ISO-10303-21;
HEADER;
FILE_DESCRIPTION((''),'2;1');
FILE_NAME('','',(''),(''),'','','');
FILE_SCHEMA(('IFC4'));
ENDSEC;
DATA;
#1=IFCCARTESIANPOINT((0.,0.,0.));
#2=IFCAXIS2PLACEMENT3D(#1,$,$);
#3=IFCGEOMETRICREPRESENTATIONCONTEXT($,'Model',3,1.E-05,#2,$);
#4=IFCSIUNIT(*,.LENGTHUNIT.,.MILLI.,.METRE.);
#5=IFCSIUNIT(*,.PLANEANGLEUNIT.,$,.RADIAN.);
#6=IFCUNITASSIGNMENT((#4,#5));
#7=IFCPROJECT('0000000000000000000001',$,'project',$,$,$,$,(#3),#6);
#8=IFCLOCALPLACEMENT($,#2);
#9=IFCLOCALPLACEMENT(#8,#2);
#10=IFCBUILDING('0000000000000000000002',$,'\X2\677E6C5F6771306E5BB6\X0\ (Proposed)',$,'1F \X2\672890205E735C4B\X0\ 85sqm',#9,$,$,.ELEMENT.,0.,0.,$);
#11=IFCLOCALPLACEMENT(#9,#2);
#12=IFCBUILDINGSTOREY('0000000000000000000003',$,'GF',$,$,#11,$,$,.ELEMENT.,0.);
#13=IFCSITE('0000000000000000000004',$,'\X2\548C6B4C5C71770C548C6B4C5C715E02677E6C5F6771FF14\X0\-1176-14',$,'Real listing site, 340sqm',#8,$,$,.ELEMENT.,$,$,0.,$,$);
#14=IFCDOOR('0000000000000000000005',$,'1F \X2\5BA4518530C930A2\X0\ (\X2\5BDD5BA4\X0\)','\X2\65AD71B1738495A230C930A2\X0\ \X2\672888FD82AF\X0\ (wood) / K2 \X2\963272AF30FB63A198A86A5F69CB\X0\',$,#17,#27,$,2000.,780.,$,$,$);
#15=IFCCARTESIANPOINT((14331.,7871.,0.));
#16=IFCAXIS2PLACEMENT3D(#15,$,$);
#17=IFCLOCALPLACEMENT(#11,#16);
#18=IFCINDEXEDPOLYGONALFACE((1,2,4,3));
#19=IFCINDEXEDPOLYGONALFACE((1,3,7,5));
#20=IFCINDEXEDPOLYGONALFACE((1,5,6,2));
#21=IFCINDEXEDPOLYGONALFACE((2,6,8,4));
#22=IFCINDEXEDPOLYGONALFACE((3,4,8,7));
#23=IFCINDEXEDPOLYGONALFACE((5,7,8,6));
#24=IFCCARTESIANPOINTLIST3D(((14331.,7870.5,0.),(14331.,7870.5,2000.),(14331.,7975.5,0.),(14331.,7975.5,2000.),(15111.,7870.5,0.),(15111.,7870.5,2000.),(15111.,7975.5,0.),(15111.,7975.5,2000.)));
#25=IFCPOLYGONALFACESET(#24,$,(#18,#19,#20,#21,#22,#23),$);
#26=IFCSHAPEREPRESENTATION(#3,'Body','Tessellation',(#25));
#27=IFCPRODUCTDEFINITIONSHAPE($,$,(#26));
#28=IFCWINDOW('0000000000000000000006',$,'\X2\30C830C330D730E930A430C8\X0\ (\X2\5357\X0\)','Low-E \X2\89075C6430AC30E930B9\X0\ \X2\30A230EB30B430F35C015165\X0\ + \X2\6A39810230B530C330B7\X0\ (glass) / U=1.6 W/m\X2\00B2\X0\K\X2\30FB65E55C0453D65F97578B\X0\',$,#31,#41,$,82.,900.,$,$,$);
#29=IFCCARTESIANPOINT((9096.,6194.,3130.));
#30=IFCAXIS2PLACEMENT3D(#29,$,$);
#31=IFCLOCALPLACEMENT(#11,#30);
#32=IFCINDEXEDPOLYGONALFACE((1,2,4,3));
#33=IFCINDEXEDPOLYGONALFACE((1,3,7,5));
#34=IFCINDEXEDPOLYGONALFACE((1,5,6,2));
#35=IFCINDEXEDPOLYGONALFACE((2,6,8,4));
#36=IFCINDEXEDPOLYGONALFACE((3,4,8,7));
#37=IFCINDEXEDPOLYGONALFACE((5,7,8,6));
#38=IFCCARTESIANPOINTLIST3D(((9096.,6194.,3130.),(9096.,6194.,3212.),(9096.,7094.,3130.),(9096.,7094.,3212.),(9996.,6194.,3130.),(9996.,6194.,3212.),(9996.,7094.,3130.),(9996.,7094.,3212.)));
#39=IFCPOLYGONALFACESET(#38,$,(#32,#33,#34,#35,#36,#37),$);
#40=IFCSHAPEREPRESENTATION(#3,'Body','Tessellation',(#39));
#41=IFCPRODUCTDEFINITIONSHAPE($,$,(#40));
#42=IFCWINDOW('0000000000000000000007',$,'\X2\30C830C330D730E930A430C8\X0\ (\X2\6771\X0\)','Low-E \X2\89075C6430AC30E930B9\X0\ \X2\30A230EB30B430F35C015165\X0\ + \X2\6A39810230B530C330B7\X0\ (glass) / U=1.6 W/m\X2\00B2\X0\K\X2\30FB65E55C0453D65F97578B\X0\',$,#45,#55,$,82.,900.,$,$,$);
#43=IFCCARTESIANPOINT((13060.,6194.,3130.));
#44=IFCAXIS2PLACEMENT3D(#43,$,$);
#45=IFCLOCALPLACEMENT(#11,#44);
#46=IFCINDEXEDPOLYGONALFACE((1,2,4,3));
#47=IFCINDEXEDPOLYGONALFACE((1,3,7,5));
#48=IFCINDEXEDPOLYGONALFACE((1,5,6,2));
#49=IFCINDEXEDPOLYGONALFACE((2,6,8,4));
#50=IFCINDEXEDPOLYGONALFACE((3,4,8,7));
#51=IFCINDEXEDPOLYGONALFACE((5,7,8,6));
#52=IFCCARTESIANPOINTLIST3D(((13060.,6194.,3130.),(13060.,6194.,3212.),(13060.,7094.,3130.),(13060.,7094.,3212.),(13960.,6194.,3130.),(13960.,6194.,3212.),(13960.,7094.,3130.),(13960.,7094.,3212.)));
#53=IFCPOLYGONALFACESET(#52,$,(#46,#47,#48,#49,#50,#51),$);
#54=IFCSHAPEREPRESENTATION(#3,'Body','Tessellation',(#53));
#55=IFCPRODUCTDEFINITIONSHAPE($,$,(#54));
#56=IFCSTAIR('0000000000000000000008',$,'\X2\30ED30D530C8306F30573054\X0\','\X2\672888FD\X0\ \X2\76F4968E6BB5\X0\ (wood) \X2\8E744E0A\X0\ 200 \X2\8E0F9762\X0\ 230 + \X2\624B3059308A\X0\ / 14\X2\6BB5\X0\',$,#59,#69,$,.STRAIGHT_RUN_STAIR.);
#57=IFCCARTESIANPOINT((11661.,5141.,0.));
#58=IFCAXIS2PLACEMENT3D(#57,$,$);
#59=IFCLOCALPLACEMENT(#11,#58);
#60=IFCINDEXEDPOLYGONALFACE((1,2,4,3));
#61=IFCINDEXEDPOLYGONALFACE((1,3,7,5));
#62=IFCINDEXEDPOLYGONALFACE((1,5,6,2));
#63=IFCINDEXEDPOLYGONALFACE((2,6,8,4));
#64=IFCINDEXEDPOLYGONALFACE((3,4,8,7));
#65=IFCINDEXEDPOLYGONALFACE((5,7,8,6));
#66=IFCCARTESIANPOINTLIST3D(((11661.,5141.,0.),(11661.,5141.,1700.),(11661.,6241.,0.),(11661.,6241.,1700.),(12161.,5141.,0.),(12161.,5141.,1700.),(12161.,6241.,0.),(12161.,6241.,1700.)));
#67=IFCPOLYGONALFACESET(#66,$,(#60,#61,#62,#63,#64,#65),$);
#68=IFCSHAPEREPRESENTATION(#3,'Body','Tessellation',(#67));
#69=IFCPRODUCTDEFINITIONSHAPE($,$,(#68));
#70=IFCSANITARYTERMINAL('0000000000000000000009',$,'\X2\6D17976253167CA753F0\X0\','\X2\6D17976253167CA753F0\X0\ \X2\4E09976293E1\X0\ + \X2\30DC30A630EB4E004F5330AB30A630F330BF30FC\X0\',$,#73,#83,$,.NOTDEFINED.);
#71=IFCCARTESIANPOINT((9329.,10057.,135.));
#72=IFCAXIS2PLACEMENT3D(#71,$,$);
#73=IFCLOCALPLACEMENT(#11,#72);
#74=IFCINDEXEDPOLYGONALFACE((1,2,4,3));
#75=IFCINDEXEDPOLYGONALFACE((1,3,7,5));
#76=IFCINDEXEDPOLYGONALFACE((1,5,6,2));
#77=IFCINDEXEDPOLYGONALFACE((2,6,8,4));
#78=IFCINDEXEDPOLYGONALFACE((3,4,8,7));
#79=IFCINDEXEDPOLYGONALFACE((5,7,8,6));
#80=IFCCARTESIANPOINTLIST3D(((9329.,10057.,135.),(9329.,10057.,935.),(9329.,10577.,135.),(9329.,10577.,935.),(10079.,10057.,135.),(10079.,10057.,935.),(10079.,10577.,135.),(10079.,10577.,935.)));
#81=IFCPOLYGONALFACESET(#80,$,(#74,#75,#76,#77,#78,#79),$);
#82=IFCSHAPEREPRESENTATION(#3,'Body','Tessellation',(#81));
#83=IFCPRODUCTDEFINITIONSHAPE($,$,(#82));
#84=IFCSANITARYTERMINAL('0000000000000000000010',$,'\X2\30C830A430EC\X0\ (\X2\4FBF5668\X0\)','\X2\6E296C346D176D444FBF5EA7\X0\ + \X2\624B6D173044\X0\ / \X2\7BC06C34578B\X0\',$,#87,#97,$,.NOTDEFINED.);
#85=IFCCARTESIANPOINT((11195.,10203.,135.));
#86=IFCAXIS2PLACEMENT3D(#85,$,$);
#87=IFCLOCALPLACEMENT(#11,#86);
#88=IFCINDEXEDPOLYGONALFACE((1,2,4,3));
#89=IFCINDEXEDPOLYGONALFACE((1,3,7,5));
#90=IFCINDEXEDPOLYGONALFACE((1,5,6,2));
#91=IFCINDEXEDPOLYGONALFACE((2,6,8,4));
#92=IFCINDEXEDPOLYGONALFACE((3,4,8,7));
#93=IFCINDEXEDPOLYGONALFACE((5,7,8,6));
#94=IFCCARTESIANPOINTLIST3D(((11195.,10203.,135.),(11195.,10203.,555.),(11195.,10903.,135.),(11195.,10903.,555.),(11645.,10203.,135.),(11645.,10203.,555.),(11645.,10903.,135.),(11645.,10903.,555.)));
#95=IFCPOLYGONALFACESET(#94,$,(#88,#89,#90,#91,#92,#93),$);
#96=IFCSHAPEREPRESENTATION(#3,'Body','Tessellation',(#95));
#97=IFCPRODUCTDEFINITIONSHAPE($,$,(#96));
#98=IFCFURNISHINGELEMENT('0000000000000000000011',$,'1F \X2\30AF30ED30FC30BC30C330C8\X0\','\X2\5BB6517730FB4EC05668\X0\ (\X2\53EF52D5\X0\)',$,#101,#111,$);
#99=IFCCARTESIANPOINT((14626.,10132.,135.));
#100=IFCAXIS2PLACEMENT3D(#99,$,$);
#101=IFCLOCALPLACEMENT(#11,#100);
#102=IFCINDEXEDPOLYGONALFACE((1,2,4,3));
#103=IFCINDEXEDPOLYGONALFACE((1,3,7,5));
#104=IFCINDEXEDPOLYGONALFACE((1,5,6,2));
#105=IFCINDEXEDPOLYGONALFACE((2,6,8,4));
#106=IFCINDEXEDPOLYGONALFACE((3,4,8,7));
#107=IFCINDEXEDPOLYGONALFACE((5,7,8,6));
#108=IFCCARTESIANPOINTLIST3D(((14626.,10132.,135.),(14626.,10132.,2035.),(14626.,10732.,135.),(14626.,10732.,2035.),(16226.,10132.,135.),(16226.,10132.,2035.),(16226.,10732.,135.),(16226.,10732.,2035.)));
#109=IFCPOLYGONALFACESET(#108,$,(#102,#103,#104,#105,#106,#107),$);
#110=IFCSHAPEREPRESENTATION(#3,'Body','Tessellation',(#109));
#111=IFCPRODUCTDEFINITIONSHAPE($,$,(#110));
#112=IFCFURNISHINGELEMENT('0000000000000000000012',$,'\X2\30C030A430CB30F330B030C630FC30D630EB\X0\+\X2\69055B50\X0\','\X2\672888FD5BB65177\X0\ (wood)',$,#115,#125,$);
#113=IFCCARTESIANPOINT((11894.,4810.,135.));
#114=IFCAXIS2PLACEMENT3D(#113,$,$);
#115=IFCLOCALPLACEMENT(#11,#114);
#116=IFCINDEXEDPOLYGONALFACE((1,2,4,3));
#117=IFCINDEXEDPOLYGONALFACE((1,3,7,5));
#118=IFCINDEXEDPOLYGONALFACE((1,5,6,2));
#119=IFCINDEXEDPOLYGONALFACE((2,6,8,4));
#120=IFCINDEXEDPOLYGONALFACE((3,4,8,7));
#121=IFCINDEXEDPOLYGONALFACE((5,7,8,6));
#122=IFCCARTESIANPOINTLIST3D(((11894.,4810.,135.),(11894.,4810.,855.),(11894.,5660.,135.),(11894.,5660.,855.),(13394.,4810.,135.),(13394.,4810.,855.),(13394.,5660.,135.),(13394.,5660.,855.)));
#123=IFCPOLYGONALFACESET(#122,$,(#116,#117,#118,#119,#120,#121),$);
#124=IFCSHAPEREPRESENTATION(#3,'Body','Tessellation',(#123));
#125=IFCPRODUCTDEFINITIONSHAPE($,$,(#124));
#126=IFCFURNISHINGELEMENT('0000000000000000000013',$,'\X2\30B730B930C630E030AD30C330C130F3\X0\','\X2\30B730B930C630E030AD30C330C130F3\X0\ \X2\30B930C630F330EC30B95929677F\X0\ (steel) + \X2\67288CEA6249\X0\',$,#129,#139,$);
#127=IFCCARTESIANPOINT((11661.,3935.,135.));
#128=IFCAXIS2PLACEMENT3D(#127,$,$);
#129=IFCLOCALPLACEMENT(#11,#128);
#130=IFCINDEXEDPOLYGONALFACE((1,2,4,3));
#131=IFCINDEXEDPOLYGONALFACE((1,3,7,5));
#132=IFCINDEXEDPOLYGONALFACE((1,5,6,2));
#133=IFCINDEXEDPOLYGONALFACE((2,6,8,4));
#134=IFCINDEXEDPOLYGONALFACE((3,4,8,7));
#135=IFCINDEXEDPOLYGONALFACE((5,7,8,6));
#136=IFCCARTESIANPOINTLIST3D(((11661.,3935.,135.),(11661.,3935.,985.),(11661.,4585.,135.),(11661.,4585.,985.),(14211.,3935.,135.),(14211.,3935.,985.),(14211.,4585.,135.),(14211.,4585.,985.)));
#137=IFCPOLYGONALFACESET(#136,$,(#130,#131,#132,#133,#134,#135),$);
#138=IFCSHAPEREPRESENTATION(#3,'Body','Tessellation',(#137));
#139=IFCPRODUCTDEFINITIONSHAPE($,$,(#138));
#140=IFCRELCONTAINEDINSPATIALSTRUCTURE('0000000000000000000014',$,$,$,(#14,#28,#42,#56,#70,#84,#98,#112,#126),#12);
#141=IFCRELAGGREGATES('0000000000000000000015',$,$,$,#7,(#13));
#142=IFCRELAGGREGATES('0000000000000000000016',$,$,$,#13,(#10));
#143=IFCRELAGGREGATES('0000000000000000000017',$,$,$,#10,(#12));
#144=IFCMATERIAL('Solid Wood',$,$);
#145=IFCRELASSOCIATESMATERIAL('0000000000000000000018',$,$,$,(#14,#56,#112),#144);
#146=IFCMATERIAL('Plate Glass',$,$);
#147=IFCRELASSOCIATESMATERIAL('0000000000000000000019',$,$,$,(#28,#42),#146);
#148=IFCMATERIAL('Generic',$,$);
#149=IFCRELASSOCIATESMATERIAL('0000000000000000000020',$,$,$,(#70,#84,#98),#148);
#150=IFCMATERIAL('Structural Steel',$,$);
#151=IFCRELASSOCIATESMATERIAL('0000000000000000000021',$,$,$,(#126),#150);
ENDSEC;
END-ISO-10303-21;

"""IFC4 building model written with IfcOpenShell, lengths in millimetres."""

from ifc_helpers import new_model, si_unit, frame, frame_2d, origin, place, context, project, spatial, rectangle, extrude, material, element, save


model = new_model("IFC4")

# Units and contexts
model_context = context("Model", 3, precision=1e-05, world=origin())
ifc_project = project(units=[si_unit("LENGTHUNIT", "METRE", prefix="MILLI"), si_unit("PLANEANGLEUNIT", "RADIAN")], contexts=[model_context])

# Site, building, storey
site_placement = place(None, origin())
site = spatial("IfcSite", under=ifc_project, at=site_placement, Name="和歌山県和歌山市松江東４-1176-14", ObjectType="Real listing site, 340sqm", CompositionType="ELEMENT", RefElevation=0.0)
building_placement = place(site_placement, origin())
building = spatial("IfcBuilding", under=site, at=building_placement, Name="松江東の家 (Proposed)", ObjectType="1F 木造平屋 85sqm", CompositionType="ELEMENT", ElevationOfRefHeight=0.0, ElevationOfTerrain=0.0)
storey_placement = place(building_placement, origin())
storey = spatial("IfcBuildingStorey", under=building, at=storey_placement, Name="GF", CompositionType="ELEMENT", Elevation=0.0)

# Shared definitions
ifc_material_1 = material(Name="Solid Wood")
ifc_material_2 = material(Name="Plate Glass")

# Door
door_placement = place(storey_placement, frame((14331.0, 7871.0, 0.0)))
element("IfcDoor", 1, at=door_placement, inside=storey, material=ifc_material_1, Name="1F 室内ドア (寝室)", Description="断熱玄関ドア 木製芯 (wood) / K2 防犯・採風機構", OverallHeight=2000.0, OverallWidth=780.0, context=model_context, shape_type="SweptSolid", body=[
    extrude(rectangle(XDim=780.0, YDim=105.0, at=frame_2d((390.0, 52.0))), frame((14331.0, 7871.0, 0.0)), (0.0, 0.0, 1.0), 2000.0),
])

# Windows
window_1_placement = place(storey_placement, frame((9096.0, 6194.0, 3130.0)))
element("IfcWindow", 2, at=window_1_placement, inside=storey, material=ifc_material_2, Name="トップライト (南)", Description="Low-E 複層ガラス アルゴン封入 + 樹脂サッシ (glass) / U=1.6 W/m²K・日射取得型", OverallHeight=82.0, OverallWidth=900.0, context=model_context, shape_type="SweptSolid", body=[
    extrude(rectangle(XDim=900.0, YDim=900.0, at=frame_2d((450.0, 450.0))), frame((9096.0, 6194.0, 3130.0)), (0.0, 0.0, 1.0), 82.0),
])
window_2_placement = place(storey_placement, frame((13060.0, 6194.0, 3130.0)))
element("IfcWindow", 3, at=window_2_placement, inside=storey, material=ifc_material_2, Name="トップライト (東)", Description="Low-E 複層ガラス アルゴン封入 + 樹脂サッシ (glass) / U=1.6 W/m²K・日射取得型", OverallHeight=82.0, OverallWidth=900.0, context=model_context, shape_type="SweptSolid", body=[
    extrude(rectangle(XDim=900.0, YDim=900.0, at=frame_2d((450.0, 450.0))), frame((13060.0, 6194.0, 3130.0)), (0.0, 0.0, 1.0), 82.0),
])

# Stair
stair_placement = place(storey_placement, frame((11661.0, 5141.0, 0.0)))
element("IfcStair", 4, at=stair_placement, inside=storey, material=ifc_material_1, Name="ロフトはしご", Description="木製 直階段 (wood) 蹴上 200 踏面 230 + 手すり / 14段", PredefinedType="STRAIGHT_RUN_STAIR", context=model_context, shape_type="SweptSolid", body=[
    extrude(rectangle(XDim=500.0, YDim=1100.0, at=frame_2d((250.0, 550.0))), frame((11661.0, 5141.0, 0.0)), (0.0, 0.0, 1.0), 1700.0),
])

# Sanitary terminals
ifc_material_3 = material(Name="Generic")
sanitary_terminal_1_placement = place(storey_placement, frame((9329.0, 10057.0, 135.0)))
element("IfcSanitaryTerminal", 5, at=sanitary_terminal_1_placement, inside=storey, material=ifc_material_3, Name="洗面化粧台", Description="洗面化粧台 三面鏡 + ボウル一体カウンター", PredefinedType="NOTDEFINED", context=model_context, shape_type="SweptSolid", body=[
    extrude(rectangle(XDim=750.0, YDim=520.0, at=frame_2d((375.0, 260.0))), frame((9329.0, 10057.0, 135.0)), (0.0, 0.0, 1.0), 800.0),
])
sanitary_terminal_2_placement = place(storey_placement, frame((11195.0, 10203.0, 135.0)))
element("IfcSanitaryTerminal", 6, at=sanitary_terminal_2_placement, inside=storey, material=ifc_material_3, Name="トイレ (便器)", Description="温水洗浄便座 + 手洗い / 節水型", PredefinedType="NOTDEFINED", context=model_context, shape_type="SweptSolid", body=[
    extrude(rectangle(XDim=450.0, YDim=700.0, at=frame_2d((225.0, 350.0))), frame((11195.0, 10203.0, 135.0)), (0.0, 0.0, 1.0), 420.0),
])

# Furnishing elements
furnishing_1_placement = place(storey_placement, frame((14626.0, 10132.0, 135.0)))
element("IfcFurnishingElement", 7, at=furnishing_1_placement, inside=storey, material=ifc_material_3, Name="1F クローゼット", Description="家具・什器 (可動)", context=model_context, shape_type="SweptSolid", body=[
    extrude(rectangle(XDim=1600.0, YDim=600.0, at=frame_2d((800.0, 300.0))), frame((14626.0, 10132.0, 135.0)), (0.0, 0.0, 1.0), 1900.0),
])
furnishing_2_placement = place(storey_placement, frame((11894.0, 4810.0, 135.0)))
element("IfcFurnishingElement", 8, at=furnishing_2_placement, inside=storey, material=ifc_material_1, Name="ダイニングテーブル+椅子", Description="木製家具 (wood)", context=model_context, shape_type="SweptSolid", body=[
    extrude(rectangle(XDim=1500.0, YDim=850.0, at=frame_2d((750.0, 425.0))), frame((11894.0, 4810.0, 135.0)), (0.0, 0.0, 1.0), 720.0),
])
ifc_material_4 = material(Name="Structural Steel")
furnishing_3_placement = place(storey_placement, frame((11661.0, 3935.0, 135.0)))
element("IfcFurnishingElement", 9, at=furnishing_3_placement, inside=storey, material=ifc_material_4, Name="システムキッチン", Description="システムキッチン ステンレス天板 (steel) + 木質扉", context=model_context, shape_type="SweptSolid", body=[
    extrude(rectangle(XDim=2550.0, YDim=650.0, at=frame_2d((1275.0, 325.0))), frame((11661.0, 3935.0, 135.0)), (0.0, 0.0, 1.0), 850.0),
])

save(model, "model.ifc")
